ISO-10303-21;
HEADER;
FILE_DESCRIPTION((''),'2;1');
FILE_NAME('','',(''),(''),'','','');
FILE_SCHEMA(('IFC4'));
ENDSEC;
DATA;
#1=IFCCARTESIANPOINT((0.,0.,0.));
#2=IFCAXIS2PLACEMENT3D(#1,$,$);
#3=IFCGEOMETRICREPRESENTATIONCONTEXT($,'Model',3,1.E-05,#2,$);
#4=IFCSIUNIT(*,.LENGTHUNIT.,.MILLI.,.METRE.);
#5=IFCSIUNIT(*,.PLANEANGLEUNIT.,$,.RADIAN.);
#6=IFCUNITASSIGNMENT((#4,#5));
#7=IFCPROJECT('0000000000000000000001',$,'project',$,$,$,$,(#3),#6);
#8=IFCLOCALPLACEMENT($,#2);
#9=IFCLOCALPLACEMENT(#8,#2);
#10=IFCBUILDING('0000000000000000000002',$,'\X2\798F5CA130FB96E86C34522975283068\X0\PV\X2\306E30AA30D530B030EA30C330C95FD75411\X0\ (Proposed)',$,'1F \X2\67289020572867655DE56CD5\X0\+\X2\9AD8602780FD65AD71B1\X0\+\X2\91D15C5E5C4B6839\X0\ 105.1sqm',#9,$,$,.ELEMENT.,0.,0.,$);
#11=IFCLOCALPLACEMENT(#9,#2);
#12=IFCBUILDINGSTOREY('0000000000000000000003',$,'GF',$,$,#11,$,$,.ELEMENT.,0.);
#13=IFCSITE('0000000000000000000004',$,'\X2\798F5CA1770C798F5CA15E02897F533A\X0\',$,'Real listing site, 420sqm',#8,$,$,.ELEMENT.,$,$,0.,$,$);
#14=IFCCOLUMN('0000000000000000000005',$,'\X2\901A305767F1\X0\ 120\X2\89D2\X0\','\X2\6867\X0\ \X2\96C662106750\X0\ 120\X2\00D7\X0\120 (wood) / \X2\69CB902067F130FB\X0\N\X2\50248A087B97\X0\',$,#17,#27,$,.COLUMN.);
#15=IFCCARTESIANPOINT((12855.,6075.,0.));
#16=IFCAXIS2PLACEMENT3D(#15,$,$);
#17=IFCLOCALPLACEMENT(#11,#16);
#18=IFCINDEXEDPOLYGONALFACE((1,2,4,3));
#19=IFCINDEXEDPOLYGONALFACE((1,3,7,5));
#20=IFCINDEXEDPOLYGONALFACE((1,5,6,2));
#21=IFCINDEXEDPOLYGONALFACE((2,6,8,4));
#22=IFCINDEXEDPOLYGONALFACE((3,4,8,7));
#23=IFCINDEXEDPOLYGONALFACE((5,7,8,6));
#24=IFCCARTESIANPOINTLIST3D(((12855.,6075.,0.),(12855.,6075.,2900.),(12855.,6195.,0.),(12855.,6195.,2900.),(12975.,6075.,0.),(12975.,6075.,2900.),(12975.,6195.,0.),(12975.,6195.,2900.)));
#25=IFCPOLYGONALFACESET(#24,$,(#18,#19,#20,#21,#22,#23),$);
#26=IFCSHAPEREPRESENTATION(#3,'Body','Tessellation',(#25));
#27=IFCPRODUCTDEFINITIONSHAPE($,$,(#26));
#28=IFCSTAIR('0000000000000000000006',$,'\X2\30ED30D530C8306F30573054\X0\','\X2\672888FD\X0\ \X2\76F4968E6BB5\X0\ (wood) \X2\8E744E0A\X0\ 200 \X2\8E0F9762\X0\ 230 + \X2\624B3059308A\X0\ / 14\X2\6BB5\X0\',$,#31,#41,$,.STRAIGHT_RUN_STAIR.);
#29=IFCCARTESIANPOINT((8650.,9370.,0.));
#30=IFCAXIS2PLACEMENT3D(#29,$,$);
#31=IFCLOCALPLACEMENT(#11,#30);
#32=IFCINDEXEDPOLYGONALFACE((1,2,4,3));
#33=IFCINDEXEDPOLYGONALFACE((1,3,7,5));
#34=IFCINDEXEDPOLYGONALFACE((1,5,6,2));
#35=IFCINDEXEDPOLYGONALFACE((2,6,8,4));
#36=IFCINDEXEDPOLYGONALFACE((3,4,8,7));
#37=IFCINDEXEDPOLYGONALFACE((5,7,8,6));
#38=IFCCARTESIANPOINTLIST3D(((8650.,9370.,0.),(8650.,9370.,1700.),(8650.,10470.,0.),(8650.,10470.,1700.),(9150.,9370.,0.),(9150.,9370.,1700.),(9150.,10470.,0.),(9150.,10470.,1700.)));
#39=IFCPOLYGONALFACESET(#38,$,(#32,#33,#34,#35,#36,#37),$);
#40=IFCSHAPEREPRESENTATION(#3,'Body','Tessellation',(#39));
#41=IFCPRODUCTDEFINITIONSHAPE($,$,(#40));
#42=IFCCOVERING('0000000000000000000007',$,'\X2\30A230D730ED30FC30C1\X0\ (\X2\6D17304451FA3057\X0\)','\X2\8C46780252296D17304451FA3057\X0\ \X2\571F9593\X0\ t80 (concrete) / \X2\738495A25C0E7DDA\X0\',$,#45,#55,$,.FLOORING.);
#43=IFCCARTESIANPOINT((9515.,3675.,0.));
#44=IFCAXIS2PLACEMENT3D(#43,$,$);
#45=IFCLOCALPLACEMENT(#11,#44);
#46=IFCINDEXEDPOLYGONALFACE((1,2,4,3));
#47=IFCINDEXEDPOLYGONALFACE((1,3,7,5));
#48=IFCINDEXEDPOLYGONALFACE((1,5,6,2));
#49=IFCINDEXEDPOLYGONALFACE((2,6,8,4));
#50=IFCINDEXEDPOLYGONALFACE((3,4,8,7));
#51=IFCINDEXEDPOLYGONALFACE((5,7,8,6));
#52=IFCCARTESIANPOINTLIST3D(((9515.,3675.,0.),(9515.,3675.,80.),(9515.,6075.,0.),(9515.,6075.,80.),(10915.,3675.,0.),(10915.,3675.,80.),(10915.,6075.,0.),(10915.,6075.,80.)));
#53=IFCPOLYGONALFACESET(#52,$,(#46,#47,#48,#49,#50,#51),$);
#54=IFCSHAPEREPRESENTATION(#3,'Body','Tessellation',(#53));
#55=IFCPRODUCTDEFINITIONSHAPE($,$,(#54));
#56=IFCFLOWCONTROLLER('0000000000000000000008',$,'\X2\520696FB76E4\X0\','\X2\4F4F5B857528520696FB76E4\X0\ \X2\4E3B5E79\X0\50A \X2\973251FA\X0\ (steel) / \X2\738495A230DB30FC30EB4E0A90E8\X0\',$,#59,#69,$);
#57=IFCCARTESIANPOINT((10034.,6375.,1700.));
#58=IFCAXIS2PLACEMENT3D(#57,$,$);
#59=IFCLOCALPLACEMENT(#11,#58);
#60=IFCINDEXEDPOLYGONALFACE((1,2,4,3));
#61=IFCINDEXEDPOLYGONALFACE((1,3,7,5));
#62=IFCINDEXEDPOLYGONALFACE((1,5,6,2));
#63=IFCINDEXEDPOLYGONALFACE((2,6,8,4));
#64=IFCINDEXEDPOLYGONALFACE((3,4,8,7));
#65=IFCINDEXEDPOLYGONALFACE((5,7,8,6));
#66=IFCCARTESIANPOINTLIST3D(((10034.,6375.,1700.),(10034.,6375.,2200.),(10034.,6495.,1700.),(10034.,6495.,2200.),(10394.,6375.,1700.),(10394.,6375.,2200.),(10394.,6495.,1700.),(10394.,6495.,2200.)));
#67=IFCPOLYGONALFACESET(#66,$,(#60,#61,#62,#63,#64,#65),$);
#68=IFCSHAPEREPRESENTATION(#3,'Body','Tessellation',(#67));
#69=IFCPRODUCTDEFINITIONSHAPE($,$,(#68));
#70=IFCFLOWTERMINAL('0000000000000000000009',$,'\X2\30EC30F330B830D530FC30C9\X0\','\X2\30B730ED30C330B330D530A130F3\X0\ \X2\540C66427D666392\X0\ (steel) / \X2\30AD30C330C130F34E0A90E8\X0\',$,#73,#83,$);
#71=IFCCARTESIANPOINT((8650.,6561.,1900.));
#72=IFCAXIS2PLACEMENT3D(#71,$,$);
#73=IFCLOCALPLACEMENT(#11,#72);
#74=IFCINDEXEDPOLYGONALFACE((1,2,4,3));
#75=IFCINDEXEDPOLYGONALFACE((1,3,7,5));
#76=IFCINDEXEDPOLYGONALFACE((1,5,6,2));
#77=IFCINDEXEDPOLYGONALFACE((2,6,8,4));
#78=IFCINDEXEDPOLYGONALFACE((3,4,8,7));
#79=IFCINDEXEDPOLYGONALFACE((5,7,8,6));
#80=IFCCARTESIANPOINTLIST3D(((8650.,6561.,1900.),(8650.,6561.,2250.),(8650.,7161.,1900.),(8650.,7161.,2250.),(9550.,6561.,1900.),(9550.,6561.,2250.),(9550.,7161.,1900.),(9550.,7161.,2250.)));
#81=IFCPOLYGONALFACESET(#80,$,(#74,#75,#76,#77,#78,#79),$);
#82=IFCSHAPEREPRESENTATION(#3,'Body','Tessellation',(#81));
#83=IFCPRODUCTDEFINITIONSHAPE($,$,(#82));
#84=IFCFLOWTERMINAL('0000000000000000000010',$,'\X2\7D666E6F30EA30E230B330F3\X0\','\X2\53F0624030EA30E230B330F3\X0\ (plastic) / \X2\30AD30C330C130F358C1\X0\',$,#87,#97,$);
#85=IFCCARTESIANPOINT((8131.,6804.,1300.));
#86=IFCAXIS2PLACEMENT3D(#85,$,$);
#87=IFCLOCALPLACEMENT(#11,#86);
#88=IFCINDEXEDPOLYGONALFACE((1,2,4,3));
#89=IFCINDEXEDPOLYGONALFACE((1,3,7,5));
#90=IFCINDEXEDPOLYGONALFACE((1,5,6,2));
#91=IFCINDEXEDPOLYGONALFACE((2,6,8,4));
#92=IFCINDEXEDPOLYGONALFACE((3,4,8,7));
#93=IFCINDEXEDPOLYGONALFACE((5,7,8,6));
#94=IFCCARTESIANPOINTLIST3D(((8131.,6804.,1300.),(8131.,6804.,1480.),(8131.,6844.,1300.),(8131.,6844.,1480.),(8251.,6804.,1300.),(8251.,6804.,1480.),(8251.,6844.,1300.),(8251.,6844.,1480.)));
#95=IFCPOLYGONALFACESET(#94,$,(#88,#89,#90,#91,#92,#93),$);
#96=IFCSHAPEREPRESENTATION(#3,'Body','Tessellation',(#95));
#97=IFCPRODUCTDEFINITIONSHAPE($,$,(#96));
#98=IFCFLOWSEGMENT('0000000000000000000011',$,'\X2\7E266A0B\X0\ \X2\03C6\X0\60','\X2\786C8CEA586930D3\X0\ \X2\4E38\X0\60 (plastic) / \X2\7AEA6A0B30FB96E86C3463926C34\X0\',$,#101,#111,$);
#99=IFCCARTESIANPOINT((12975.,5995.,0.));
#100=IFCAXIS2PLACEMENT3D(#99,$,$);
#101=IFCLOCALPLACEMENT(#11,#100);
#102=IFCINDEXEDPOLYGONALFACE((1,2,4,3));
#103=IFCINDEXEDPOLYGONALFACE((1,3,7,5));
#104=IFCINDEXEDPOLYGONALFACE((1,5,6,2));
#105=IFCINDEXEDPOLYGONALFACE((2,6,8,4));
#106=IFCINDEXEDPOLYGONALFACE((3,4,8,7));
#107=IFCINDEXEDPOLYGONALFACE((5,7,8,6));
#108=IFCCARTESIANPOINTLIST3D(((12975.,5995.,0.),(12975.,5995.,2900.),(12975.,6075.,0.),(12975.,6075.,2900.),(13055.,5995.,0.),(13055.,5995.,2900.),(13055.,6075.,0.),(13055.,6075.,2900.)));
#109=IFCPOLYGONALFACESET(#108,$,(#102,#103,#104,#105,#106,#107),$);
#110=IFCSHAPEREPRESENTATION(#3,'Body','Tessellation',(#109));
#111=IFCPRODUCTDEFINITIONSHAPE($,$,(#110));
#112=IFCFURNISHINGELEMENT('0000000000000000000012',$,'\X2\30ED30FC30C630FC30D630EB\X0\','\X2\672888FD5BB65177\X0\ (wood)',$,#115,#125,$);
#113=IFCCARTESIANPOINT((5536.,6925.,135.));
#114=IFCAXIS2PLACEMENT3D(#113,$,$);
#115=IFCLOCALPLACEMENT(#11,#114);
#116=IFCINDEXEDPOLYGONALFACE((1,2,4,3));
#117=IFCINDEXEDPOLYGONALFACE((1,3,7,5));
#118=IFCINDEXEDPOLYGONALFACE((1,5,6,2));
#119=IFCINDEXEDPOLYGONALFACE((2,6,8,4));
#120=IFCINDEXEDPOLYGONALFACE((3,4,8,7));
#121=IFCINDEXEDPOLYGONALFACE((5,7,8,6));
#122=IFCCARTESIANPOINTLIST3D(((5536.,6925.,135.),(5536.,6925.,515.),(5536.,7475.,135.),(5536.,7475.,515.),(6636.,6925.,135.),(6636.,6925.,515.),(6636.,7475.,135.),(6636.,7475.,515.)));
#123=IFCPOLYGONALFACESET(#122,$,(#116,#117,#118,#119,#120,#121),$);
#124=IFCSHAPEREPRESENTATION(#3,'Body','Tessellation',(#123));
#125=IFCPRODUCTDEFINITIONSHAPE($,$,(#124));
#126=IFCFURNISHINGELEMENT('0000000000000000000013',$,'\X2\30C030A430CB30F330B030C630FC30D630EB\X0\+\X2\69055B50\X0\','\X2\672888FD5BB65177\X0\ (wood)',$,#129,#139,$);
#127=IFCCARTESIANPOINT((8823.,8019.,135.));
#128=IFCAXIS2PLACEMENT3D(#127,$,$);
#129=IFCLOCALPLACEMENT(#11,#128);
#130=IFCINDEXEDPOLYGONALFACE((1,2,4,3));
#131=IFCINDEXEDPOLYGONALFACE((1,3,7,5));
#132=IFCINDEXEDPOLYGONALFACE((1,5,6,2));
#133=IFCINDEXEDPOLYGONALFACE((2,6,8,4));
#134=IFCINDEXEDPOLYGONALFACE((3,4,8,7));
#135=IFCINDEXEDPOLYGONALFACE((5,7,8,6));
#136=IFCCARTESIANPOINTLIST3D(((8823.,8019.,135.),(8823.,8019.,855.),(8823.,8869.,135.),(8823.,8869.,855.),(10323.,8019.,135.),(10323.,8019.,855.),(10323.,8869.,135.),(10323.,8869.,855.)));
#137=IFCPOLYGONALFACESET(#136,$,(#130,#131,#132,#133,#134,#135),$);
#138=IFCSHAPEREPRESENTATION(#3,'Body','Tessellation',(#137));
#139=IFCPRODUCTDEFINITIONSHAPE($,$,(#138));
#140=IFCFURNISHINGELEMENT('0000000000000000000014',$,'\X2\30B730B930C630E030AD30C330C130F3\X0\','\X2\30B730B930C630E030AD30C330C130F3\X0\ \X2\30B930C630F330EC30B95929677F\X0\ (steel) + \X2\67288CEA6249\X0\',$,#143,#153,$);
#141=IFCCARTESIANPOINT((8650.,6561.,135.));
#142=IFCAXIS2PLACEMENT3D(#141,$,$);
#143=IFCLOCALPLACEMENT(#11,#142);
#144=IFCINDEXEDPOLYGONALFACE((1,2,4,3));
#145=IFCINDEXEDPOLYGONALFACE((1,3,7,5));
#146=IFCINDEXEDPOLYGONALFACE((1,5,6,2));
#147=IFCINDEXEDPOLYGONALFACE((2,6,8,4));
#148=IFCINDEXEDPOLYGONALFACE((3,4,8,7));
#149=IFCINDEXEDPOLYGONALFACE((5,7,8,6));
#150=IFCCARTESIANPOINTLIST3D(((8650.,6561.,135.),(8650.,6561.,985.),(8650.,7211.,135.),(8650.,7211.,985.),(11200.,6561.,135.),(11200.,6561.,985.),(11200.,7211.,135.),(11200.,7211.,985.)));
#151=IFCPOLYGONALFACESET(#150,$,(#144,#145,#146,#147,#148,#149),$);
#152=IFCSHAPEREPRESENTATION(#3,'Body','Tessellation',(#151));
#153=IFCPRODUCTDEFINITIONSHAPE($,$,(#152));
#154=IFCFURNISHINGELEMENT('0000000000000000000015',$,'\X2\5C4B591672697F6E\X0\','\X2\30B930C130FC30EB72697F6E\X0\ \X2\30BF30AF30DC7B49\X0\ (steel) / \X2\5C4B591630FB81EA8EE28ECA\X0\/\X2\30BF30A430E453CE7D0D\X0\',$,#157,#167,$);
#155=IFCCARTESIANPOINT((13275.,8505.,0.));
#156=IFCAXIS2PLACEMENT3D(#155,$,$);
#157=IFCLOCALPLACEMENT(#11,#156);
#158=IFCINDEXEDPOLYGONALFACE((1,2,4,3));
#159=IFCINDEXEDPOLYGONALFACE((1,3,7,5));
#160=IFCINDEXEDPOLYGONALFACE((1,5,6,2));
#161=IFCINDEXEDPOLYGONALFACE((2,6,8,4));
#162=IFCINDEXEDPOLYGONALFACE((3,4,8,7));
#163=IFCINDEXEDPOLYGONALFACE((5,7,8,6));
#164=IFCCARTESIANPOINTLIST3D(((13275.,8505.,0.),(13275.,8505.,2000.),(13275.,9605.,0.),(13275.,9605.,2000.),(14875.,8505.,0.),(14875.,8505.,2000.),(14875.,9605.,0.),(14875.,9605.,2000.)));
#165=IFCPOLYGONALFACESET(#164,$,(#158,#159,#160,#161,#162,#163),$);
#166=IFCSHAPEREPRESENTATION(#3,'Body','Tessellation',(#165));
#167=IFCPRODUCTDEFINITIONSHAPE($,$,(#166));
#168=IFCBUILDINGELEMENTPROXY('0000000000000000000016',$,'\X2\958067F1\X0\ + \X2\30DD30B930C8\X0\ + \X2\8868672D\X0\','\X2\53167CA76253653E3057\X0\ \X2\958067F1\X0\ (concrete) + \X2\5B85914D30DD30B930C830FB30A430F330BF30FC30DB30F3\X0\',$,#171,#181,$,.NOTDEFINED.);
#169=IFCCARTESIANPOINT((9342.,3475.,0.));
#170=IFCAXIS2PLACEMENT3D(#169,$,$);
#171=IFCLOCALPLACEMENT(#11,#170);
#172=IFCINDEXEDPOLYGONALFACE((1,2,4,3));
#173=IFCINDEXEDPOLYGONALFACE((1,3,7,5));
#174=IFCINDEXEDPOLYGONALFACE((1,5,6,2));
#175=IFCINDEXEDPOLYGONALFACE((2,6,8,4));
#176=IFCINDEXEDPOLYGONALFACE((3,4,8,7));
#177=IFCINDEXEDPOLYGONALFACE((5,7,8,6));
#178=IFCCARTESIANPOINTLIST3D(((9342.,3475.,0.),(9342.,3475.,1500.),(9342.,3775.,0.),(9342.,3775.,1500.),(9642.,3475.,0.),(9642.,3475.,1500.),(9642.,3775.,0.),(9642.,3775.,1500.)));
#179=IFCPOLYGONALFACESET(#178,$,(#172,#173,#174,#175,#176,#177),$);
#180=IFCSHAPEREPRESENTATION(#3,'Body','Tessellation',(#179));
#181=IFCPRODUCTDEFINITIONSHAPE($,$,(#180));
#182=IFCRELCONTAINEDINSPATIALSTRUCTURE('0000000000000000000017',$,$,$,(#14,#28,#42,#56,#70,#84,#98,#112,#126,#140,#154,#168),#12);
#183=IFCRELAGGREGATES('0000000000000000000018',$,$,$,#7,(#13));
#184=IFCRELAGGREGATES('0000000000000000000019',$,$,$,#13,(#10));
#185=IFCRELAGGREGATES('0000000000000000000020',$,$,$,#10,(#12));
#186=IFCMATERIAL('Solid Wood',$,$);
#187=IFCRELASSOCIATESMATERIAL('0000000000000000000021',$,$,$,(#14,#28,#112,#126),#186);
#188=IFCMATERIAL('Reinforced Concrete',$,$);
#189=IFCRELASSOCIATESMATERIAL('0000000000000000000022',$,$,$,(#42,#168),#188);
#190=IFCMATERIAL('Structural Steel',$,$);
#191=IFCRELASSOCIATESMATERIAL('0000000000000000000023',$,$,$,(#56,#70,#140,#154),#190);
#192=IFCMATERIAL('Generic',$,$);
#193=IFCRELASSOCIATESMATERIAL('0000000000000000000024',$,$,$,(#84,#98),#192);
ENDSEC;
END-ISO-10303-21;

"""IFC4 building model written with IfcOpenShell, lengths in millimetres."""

from ifc_helpers import new_model, si_unit, frame, frame_2d, origin, place, context, project, spatial, rectangle, extrude, material, element, save


model = new_model("IFC4")

# Units and contexts
model_context = context("Model", 3, precision=1e-05, world=origin())
ifc_project = project(units=[si_unit("LENGTHUNIT", "METRE", prefix="MILLI"), si_unit("PLANEANGLEUNIT", "RADIAN")], contexts=[model_context])

# Site, building, storey
site_placement = place(None, origin())
site = spatial("IfcSite", under=ifc_project, at=site_placement, Name="福岡県福岡市西区", ObjectType="Real listing site, 420sqm", CompositionType="ELEMENT", RefElevation=0.0)
building_placement = place(site_placement, origin())
building = spatial("IfcBuilding", under=site, at=building_placement, Name="福岡・雨水利用とPVのオフグリッド志向 (Proposed)", ObjectType="1F 木造在来工法+高性能断熱+金属屋根 105.1sqm", CompositionType="ELEMENT", ElevationOfRefHeight=0.0, ElevationOfTerrain=0.0)
storey_placement = place(building_placement, origin())
storey = spatial("IfcBuildingStorey", under=building, at=storey_placement, Name="GF", CompositionType="ELEMENT", Elevation=0.0)

# Column
ifc_material_1 = material(Name="Solid Wood")
column_1_placement = place(storey_placement, frame((12855.0, 6075.0, 0.0)))
element("IfcColumn", 1, at=column_1_placement, inside=storey, material=ifc_material_1, Name="通し柱 120角", Description="桧 集成材 120×120 (wood) / 構造柱・N値計算", PredefinedType="COLUMN", context=model_context, shape_type="SweptSolid", body=[
    extrude(rectangle(XDim=120.0, YDim=120.0, at=frame_2d((60.0, 60.0))), frame((12855.0, 6075.0, 0.0)), (0.0, 0.0, 1.0), 2900.0),
])

# Stair
stair_placement = place(storey_placement, frame((8650.0, 9370.0, 0.0)))
element("IfcStair", 2, at=stair_placement, inside=storey, material=ifc_material_1, Name="ロフトはしご", Description="木製 直階段 (wood) 蹴上 200 踏面 230 + 手すり / 14段", PredefinedType="STRAIGHT_RUN_STAIR", context=model_context, shape_type="SweptSolid", body=[
    extrude(rectangle(XDim=500.0, YDim=1100.0, at=frame_2d((250.0, 550.0))), frame((8650.0, 9370.0, 0.0)), (0.0, 0.0, 1.0), 1700.0),
])

# Covering
ifc_material_2 = material(Name="Reinforced Concrete")
covering_placement = place(storey_placement, frame((9515.0, 3675.0, 0.0)))
element("IfcCovering", 3, at=covering_placement, inside=storey, material=ifc_material_2, Name="アプローチ (洗い出し)", Description="豆砂利洗い出し 土間 t80 (concrete) / 玄関導線", PredefinedType="FLOORING", context=model_context, shape_type="SweptSolid", body=[
    extrude(rectangle(XDim=1400.0, YDim=2400.0, at=frame_2d((700.0, 1200.0))), frame((9515.0, 3675.0, 0.0)), (0.0, 0.0, 1.0), 80.0),
])

# Flow controller
ifc_material_3 = material(Name="Structural Steel")
flow_controller_placement = place(storey_placement, frame((10034.0, 6375.0, 1700.0)))
element("IfcFlowController", 4, at=flow_controller_placement, inside=storey, material=ifc_material_3, Name="分電盤", Description="住宅用分電盤 主幹50A 露出 (steel) / 玄関ホール上部", context=model_context, shape_type="SweptSolid", body=[
    extrude(rectangle(XDim=360.0, YDim=120.0, at=frame_2d((180.0, 60.0))), frame((10034.0, 6375.0, 1700.0)), (0.0, 0.0, 1.0), 500.0),
])

# Flow terminals
flow_terminal_1_placement = place(storey_placement, frame((8650.0, 6561.0, 1900.0)))
element("IfcFlowTerminal", 5, at=flow_terminal_1_placement, inside=storey, material=ifc_material_3, Name="レンジフード", Description="シロッコファン 同時給排 (steel) / キッチン上部", context=model_context, shape_type="SweptSolid", body=[
    extrude(rectangle(XDim=900.0, YDim=600.0, at=frame_2d((450.0, 300.0))), frame((8650.0, 6561.0, 1900.0)), (0.0, 0.0, 1.0), 350.0),
])
ifc_material_4 = material(Name="Generic")
flow_terminal_2_placement = place(storey_placement, frame((8131.0, 6804.0, 1300.0)))
element("IfcFlowTerminal", 6, at=flow_terminal_2_placement, inside=storey, material=ifc_material_4, Name="給湯リモコン", Description="台所リモコン (plastic) / キッチン壁", context=model_context, shape_type="SweptSolid", body=[
    extrude(rectangle(XDim=120.0, YDim=40.0, at=frame_2d((60.0, 20.0))), frame((8131.0, 6804.0, 1300.0)), (0.0, 0.0, 1.0), 180.0),
])

# Flow segment
flow_segment_placement = place(storey_placement, frame((12975.0, 5995.0, 0.0)))
element("IfcFlowSegment", 7, at=flow_segment_placement, inside=storey, material=ifc_material_4, Name="縦樋 φ60", Description="硬質塩ビ 丸60 (plastic) / 竪樋・雨水排水", context=model_context, shape_type="SweptSolid", body=[
    extrude(rectangle(XDim=80.0, YDim=80.0, at=frame_2d((40.0, 40.0))), frame((12975.0, 5995.0, 0.0)), (0.0, 0.0, 1.0), 2900.0),
])

# Furnishing elements
furnishing_1_placement = place(storey_placement, frame((5536.0, 6925.0, 135.0)))
element("IfcFurnishingElement", 8, at=furnishing_1_placement, inside=storey, material=ifc_material_1, Name="ローテーブル", Description="木製家具 (wood)", context=model_context, shape_type="SweptSolid", body=[
    extrude(rectangle(XDim=1100.0, YDim=550.0, at=frame_2d((550.0, 275.0))), frame((5536.0, 6925.0, 135.0)), (0.0, 0.0, 1.0), 380.0),
])
furnishing_2_placement = place(storey_placement, frame((8823.0, 8019.0, 135.0)))
element("IfcFurnishingElement", 9, at=furnishing_2_placement, inside=storey, material=ifc_material_1, Name="ダイニングテーブル+椅子", Description="木製家具 (wood)", context=model_context, shape_type="SweptSolid", body=[
    extrude(rectangle(XDim=1500.0, YDim=850.0, at=frame_2d((750.0, 425.0))), frame((8823.0, 8019.0, 135.0)), (0.0, 0.0, 1.0), 720.0),
])
furnishing_3_placement = place(storey_placement, frame((8650.0, 6561.0, 135.0)))
element("IfcFurnishingElement", 10, at=furnishing_3_placement, inside=storey, material=ifc_material_3, Name="システムキッチン", Description="システムキッチン ステンレス天板 (steel) + 木質扉", context=model_context, shape_type="SweptSolid", body=[
    extrude(rectangle(XDim=2550.0, YDim=650.0, at=frame_2d((1275.0, 325.0))), frame((8650.0, 6561.0, 135.0)), (0.0, 0.0, 1.0), 850.0),
])
furnishing_4_placement = place(storey_placement, frame((13275.0, 8505.0, 0.0)))
element("IfcFurnishingElement", 11, at=furnishing_4_placement, inside=storey, material=ifc_material_3, Name="屋外物置", Description="スチール物置 タクボ等 (steel) / 屋外・自転車/タイヤ収納", context=model_context, shape_type="SweptSolid", body=[
    extrude(rectangle(XDim=1600.0, YDim=1100.0, at=frame_2d((800.0, 550.0))), frame((13275.0, 8505.0, 0.0)), (0.0, 0.0, 1.0), 2000.0),
])

# Building element proxy
proxy_placement = place(storey_placement, frame((9342.0, 3475.0, 0.0)))
element("IfcBuildingElementProxy", 12, at=proxy_placement, inside=storey, material=ifc_material_2, Name="門柱 + ポスト + 表札", Description="化粧打放し 門柱 (concrete) + 宅配ポスト・インターホン", PredefinedType="NOTDEFINED", context=model_context, shape_type="SweptSolid", body=[
    extrude(rectangle(XDim=300.0, YDim=300.0, at=frame_2d((150.0, 150.0))), frame((9342.0, 3475.0, 0.0)), (0.0, 0.0, 1.0), 1500.0),
])

save(model, "model.ifc")
